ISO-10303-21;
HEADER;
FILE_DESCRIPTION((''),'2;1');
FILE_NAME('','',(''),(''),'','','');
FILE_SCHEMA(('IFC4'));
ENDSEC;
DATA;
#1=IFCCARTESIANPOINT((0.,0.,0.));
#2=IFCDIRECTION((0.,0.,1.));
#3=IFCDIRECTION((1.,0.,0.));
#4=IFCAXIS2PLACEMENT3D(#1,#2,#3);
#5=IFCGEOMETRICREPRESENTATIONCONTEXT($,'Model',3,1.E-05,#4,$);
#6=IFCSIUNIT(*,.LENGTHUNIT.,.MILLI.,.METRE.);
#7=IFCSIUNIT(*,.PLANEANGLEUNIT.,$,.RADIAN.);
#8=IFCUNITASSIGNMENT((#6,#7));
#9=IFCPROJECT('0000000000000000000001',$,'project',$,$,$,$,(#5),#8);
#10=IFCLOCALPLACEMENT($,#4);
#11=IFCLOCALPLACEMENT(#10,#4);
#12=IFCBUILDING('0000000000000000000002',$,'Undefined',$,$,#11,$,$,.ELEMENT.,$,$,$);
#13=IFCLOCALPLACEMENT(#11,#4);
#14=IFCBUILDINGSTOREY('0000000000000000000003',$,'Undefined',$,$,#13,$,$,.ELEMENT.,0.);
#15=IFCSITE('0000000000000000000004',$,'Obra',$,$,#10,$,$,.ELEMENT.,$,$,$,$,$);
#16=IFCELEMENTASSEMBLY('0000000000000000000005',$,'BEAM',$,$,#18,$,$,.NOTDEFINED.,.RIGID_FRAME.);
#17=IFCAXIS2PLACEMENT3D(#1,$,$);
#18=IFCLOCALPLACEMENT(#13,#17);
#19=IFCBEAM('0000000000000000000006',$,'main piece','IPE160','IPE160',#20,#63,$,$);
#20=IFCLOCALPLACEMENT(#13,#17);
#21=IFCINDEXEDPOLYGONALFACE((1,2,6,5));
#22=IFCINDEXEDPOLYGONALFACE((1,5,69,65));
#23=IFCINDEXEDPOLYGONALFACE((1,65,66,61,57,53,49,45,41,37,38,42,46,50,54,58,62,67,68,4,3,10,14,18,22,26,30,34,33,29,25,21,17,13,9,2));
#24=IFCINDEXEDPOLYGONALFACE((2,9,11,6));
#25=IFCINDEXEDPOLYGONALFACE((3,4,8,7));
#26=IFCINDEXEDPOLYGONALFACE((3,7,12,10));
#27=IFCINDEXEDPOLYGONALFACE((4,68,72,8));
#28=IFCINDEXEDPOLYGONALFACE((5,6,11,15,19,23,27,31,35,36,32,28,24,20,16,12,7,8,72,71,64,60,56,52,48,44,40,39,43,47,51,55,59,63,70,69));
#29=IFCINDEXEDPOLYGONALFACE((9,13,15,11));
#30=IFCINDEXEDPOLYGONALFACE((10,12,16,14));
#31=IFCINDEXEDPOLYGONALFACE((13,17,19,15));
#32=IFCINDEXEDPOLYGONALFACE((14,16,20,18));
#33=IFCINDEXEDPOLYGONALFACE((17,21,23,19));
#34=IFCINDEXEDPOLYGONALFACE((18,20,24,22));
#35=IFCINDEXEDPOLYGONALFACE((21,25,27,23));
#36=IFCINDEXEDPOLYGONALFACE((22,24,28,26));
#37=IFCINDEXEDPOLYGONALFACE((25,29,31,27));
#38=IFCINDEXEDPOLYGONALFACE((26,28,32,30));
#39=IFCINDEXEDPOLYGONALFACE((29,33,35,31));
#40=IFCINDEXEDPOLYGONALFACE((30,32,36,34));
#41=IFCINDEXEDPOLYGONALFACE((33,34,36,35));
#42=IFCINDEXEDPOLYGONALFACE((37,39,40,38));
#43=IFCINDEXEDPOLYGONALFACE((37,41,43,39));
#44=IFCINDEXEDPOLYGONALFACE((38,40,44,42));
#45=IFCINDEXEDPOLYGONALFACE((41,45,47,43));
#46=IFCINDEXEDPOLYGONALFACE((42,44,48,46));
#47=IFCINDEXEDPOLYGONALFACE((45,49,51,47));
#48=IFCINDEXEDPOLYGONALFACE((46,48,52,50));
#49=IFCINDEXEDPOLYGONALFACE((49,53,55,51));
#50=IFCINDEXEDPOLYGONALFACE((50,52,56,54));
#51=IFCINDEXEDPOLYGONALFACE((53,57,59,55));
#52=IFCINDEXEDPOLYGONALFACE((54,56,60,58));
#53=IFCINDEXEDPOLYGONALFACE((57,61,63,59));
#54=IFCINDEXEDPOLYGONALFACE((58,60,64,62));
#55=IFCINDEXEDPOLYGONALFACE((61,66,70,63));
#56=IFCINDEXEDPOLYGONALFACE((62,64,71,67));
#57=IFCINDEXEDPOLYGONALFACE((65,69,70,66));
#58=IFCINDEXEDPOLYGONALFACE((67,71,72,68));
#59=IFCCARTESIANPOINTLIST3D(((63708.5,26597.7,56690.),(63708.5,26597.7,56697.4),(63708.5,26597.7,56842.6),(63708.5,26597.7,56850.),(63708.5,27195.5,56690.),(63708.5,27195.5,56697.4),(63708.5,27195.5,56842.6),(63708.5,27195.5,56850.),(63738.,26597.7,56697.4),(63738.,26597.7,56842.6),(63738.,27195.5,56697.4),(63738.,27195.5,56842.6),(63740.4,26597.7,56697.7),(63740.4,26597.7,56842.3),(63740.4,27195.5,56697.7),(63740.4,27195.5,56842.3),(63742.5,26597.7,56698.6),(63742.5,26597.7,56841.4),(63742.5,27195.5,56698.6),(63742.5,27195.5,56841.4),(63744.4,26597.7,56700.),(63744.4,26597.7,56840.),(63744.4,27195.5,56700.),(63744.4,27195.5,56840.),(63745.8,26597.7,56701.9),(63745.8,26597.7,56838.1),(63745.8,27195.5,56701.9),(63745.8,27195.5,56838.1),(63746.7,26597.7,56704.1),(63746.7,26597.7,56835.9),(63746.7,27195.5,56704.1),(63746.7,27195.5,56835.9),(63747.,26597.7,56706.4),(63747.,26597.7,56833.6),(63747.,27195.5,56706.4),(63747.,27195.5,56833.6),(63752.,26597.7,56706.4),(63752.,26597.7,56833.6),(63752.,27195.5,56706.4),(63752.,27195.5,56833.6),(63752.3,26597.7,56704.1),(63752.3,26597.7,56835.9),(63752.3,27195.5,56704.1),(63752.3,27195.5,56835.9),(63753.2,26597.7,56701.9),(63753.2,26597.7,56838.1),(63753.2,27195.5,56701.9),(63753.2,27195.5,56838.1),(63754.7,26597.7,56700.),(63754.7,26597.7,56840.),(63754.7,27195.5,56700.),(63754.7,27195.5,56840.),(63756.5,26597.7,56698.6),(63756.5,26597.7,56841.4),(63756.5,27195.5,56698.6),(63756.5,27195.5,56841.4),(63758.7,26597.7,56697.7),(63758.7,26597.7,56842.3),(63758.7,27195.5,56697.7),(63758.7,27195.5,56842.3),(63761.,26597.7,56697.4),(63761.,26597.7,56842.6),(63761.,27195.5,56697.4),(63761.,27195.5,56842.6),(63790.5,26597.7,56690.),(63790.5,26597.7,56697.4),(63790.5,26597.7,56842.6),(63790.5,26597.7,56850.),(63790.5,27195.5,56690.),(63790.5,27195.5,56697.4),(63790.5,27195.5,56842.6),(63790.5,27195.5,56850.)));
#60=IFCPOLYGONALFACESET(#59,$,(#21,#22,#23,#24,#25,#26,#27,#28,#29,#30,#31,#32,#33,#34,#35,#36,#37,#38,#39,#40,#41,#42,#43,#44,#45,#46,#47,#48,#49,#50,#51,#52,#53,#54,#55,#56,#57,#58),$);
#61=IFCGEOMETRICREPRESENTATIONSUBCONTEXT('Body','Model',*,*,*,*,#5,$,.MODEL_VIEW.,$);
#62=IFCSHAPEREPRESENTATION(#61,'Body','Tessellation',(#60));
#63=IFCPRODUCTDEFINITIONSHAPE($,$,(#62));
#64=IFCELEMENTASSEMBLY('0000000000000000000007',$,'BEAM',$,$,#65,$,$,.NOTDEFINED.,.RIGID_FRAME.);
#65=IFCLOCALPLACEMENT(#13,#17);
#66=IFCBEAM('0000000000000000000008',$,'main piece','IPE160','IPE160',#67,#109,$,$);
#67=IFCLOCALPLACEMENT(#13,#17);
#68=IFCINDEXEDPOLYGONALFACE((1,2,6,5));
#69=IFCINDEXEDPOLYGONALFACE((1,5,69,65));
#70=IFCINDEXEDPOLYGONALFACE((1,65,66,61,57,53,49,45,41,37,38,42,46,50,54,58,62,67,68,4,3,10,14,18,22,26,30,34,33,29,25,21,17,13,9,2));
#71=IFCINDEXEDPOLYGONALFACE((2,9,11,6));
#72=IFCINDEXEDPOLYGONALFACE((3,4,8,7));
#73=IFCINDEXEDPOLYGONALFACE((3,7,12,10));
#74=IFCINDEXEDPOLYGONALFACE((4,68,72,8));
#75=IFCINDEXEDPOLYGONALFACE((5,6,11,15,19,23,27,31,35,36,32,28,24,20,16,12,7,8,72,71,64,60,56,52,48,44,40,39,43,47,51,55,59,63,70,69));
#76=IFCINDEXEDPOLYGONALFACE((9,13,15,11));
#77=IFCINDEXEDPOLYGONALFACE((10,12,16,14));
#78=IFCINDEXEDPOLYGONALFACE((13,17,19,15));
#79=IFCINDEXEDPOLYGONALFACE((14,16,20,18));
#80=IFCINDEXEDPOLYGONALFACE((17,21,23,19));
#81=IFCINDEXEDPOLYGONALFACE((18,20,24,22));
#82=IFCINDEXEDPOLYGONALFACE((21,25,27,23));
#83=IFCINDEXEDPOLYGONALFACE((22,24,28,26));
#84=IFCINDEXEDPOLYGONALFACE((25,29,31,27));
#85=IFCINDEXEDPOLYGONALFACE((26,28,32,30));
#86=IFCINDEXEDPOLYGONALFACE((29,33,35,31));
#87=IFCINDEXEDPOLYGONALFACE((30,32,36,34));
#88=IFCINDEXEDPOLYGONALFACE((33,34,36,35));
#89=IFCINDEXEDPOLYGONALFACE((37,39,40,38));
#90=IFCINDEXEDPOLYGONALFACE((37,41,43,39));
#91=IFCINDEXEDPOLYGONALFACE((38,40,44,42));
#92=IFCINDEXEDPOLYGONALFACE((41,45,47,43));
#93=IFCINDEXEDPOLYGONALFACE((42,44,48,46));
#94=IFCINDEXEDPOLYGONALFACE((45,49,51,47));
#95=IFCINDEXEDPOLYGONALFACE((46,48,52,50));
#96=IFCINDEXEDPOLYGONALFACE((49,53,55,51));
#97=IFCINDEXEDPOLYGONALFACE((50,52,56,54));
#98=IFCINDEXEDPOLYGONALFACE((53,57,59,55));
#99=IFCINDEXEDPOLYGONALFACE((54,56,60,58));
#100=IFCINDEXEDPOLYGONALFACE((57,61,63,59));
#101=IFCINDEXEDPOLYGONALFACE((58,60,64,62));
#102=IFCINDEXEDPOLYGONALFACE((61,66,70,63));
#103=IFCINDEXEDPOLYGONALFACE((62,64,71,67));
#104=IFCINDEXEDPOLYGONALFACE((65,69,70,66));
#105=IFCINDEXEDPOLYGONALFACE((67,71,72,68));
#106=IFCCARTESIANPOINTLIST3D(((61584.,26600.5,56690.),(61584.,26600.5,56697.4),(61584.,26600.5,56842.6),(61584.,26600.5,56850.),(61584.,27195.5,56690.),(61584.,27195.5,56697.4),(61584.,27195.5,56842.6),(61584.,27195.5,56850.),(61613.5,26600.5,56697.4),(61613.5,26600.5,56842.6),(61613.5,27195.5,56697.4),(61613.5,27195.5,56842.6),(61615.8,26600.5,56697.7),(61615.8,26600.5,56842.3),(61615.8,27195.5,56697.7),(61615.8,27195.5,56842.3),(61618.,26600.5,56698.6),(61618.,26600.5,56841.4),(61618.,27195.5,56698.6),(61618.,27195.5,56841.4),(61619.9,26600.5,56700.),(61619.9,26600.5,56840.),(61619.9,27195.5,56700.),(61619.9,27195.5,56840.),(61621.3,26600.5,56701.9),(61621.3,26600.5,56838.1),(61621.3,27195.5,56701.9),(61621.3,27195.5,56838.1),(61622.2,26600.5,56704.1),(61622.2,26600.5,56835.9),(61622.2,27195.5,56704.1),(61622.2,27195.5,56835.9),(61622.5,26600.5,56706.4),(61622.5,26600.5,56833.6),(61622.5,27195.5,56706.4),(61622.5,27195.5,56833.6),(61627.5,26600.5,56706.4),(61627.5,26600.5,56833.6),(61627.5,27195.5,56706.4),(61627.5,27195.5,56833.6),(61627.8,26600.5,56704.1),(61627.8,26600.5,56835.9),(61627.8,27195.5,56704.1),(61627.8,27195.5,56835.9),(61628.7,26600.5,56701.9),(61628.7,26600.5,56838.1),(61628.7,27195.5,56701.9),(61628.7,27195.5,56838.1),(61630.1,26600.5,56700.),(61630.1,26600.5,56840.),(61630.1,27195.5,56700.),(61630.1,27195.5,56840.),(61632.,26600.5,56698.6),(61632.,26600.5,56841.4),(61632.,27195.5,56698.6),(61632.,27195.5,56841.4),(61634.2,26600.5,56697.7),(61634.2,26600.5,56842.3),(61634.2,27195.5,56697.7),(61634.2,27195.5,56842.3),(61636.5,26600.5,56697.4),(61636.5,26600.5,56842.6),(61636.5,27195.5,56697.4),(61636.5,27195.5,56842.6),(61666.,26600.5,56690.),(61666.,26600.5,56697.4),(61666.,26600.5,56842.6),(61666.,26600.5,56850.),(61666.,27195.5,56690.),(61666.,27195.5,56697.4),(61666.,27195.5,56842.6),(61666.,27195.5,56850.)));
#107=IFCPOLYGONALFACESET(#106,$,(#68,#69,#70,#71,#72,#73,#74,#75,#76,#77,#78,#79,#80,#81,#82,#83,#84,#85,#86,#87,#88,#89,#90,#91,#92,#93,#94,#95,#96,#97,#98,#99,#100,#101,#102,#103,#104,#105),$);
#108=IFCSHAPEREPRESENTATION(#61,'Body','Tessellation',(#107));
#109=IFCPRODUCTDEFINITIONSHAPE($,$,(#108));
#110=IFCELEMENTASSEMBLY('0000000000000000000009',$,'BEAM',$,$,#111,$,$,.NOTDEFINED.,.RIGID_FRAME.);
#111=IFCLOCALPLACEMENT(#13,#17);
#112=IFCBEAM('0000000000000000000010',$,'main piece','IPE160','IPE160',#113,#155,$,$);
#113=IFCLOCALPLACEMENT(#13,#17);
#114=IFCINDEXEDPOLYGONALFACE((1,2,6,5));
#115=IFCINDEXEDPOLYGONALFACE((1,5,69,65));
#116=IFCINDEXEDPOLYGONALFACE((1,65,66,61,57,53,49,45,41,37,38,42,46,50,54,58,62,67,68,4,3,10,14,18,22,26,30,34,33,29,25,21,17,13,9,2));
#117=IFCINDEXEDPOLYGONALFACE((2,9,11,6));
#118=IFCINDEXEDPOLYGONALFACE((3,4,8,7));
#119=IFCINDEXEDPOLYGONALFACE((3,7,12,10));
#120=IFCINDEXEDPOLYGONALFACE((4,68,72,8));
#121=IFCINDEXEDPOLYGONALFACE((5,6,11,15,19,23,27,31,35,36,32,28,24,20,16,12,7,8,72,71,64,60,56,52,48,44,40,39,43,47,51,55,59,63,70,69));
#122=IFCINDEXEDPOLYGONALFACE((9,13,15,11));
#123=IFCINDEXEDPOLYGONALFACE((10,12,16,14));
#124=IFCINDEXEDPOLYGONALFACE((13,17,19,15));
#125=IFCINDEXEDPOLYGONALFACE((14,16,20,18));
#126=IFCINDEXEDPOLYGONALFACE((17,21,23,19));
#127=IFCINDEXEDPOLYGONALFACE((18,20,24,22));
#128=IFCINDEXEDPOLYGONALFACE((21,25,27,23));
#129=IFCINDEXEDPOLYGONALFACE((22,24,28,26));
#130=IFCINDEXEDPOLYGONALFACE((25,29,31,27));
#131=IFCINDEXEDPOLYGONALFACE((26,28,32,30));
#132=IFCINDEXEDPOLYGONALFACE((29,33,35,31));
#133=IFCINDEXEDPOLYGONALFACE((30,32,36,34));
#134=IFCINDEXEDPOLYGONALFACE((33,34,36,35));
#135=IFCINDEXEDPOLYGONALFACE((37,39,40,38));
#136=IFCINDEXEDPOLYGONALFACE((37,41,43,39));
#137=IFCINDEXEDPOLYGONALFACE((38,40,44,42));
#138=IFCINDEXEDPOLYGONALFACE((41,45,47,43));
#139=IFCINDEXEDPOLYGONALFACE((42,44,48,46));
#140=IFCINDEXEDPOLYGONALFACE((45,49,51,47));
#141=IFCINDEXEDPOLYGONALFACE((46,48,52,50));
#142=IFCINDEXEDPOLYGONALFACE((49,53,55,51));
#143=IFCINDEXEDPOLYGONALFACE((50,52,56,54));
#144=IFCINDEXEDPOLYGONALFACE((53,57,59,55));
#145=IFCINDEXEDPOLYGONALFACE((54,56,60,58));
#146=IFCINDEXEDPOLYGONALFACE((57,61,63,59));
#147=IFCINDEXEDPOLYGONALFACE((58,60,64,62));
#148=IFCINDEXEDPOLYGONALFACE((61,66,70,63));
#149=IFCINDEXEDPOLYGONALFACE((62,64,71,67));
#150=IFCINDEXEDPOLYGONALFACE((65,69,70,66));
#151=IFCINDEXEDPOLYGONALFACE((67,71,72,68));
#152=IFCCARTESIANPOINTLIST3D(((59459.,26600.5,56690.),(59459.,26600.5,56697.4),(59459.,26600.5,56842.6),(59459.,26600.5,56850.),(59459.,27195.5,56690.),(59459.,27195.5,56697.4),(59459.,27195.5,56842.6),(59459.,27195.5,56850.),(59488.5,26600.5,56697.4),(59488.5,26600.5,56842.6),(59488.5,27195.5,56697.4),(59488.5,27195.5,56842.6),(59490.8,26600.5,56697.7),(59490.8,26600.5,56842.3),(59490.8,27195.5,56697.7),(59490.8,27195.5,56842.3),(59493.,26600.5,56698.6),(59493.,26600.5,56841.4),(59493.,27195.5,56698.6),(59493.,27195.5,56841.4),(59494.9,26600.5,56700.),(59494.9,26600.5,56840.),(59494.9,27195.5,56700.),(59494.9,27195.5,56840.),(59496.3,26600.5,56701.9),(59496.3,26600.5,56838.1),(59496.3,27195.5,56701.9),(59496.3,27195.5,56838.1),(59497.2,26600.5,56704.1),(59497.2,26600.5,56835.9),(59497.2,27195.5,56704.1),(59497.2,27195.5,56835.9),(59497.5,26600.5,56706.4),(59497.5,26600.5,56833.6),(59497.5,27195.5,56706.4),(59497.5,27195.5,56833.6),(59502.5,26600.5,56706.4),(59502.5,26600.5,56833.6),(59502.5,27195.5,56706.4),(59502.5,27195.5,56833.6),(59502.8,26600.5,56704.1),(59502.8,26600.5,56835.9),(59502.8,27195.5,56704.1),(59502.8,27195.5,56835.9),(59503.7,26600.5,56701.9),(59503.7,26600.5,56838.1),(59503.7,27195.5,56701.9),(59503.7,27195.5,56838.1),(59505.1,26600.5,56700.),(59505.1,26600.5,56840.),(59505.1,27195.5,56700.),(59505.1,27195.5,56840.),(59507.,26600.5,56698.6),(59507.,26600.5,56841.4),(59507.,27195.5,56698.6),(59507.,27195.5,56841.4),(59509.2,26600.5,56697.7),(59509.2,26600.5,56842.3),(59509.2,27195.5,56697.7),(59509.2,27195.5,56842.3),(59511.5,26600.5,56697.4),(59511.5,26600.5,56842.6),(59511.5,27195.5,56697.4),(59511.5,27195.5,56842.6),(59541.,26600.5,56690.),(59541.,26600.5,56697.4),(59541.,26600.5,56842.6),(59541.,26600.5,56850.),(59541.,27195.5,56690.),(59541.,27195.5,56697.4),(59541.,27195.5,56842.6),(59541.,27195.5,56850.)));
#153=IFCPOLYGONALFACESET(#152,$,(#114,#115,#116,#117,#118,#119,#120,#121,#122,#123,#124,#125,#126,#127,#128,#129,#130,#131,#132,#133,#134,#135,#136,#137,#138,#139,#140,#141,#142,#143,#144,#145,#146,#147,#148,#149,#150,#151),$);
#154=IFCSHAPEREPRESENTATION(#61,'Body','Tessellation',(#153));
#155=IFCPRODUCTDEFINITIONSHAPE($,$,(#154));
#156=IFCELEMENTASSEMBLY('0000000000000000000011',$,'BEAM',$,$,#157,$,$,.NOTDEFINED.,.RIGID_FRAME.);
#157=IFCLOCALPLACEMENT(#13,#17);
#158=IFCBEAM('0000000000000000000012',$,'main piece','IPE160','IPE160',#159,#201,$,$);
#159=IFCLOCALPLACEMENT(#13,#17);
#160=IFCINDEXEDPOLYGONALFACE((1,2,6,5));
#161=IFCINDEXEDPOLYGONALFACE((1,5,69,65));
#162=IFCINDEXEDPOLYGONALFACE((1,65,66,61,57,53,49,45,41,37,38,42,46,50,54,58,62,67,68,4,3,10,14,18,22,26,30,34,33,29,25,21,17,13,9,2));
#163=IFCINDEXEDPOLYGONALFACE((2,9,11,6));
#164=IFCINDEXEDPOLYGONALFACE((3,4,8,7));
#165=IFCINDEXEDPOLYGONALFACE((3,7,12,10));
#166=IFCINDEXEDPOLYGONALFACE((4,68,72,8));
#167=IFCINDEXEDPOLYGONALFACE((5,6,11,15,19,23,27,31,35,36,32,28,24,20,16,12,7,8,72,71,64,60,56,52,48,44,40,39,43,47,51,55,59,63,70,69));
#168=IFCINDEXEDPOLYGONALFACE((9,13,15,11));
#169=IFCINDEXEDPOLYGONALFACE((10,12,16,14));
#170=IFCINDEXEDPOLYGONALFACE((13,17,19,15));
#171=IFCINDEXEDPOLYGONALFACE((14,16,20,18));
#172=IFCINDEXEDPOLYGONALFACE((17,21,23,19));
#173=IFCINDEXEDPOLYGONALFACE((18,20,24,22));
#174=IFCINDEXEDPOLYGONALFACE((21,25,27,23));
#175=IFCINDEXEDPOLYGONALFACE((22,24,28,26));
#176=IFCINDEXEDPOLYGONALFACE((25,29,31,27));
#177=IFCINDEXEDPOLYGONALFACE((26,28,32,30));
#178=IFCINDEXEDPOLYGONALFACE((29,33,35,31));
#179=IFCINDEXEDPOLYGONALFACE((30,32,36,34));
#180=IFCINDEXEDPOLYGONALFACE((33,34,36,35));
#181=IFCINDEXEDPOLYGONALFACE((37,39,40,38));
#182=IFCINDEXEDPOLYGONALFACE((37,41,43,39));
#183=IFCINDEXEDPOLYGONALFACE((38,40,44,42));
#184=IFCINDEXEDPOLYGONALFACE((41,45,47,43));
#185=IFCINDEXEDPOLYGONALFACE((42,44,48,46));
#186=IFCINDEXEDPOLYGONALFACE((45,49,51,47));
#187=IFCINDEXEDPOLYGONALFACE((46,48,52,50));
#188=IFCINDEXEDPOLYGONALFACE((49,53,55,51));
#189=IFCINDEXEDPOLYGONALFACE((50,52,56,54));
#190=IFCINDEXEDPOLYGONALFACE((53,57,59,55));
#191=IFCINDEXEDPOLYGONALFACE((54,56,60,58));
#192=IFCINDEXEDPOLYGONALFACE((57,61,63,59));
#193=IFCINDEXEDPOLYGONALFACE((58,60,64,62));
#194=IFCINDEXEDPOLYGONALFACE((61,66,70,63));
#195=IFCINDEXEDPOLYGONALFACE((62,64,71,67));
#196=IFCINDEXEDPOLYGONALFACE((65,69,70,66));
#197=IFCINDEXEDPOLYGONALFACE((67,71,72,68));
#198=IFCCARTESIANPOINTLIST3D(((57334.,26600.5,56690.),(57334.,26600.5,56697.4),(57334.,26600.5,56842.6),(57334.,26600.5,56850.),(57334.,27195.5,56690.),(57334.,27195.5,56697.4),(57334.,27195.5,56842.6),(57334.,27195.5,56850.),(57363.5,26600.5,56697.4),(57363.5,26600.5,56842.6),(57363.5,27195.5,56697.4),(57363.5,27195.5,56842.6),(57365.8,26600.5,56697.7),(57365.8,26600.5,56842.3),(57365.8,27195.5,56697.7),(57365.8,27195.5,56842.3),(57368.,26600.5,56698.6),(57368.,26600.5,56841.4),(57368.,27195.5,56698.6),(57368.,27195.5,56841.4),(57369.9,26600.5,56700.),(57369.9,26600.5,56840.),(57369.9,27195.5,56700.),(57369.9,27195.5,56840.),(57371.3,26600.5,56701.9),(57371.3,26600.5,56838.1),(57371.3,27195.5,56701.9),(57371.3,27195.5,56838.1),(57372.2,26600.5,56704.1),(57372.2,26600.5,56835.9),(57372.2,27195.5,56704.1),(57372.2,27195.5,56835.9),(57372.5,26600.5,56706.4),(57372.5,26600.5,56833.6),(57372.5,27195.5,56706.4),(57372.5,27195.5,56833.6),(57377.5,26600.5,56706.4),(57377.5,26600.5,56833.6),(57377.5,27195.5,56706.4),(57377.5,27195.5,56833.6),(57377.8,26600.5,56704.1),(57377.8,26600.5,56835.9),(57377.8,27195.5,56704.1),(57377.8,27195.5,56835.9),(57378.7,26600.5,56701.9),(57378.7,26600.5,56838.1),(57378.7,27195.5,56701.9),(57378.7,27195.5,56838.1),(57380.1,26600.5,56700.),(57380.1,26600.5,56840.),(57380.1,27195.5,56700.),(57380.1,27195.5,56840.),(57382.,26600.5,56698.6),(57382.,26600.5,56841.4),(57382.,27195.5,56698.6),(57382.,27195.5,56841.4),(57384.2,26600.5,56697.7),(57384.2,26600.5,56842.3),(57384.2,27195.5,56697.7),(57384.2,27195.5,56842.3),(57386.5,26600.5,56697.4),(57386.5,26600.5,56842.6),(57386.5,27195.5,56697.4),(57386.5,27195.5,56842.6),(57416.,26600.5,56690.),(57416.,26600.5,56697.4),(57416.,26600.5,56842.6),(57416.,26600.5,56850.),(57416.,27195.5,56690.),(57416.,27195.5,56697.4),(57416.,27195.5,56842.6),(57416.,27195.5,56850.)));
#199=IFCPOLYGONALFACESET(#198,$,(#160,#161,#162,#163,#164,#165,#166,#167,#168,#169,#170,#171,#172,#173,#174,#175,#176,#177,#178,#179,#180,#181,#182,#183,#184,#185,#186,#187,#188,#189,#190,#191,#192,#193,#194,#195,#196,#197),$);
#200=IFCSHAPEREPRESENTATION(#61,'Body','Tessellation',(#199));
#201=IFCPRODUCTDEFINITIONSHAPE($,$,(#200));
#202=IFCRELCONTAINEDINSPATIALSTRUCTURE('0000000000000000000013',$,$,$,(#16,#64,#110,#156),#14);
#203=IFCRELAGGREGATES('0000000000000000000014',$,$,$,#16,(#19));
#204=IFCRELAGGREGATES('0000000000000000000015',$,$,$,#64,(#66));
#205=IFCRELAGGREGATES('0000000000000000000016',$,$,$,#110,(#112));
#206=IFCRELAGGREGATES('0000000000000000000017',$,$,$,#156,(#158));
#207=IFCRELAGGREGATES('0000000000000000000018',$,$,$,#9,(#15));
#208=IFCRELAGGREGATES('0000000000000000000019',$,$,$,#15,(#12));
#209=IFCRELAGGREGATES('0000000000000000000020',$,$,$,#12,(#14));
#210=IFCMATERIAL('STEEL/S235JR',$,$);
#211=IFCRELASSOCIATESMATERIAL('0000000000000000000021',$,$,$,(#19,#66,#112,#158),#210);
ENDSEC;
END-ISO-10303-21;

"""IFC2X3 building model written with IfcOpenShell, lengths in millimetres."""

from ifc_helpers import new_model, si_unit, frame, origin_with_axes, origin_2d_with_axis, place, context, subcontext, project, spatial, i_section, extrude, material, element, aggregate, save


model = new_model("IFC2X3")

# Units and contexts
model_context = context("Model", 3, precision=1e-05, world=origin_with_axes())
body_context = subcontext(model_context, "Body", "Model", "MODEL_VIEW")
ifc_project = project(units=[si_unit("LENGTHUNIT", "METRE", prefix="MILLI"), si_unit("PLANEANGLEUNIT", "RADIAN")], contexts=[model_context])

# Site, building, storey
site_placement = place(None, origin_with_axes())
site = spatial("IfcSite", under=ifc_project, at=site_placement, Name="Obra", CompositionType="ELEMENT")
building_placement = place(site_placement, origin_with_axes())
building = spatial("IfcBuilding", under=site, at=building_placement, Name="Undefined", CompositionType="ELEMENT")
storey_placement = place(building_placement, origin_with_axes())
storey = spatial("IfcBuildingStorey", under=building, at=storey_placement, Name="Undefined", CompositionType="ELEMENT", Elevation=0.0)

# Element assemblies, beams
ifc_material_1 = material(Name="STEEL/S235JR")
assembly_1_placement = place(storey_placement, origin_with_axes())
assembly_1 = element("IfcElementAssembly", 1, at=assembly_1_placement, inside=storey, Name="BEAM", AssemblyPlace="NOTDEFINED", PredefinedType="RIGID_FRAME")
beam_1_placement = place(assembly_1_placement, frame((63749.5, 26597.7, 56770.0), z_axis=(0.0, 0.0, 1.0), x_axis=(0.0, 1.0, 0.0)))
beam_1 = element("IfcBeam", 2, at=beam_1_placement, material=ifc_material_1, Name="main piece", Description="IPE160", ObjectType="IPE160", context=body_context, shape_type="SweptSolid", body=[
    extrude(i_section(OverallWidth=82.0, OverallDepth=160.0, WebThickness=5.0, FlangeThickness=7.4, FilletRadius=9.0, at=origin_2d_with_axis()), frame((597.8, 0.0, 0.0), z_axis=(-1.0, 0.0, 0.0), x_axis=(0.0, -1.0, 0.0)), (0.0, 0.0, 1.0), 597.8),
])
aggregate(assembly_1, [beam_1])
assembly_2_placement = place(storey_placement, origin_with_axes())
assembly_2 = element("IfcElementAssembly", 3, at=assembly_2_placement, inside=storey, Name="BEAM", AssemblyPlace="NOTDEFINED", PredefinedType="RIGID_FRAME")
beam_2_placement = place(assembly_2_placement, frame((61625.0, 27195.5, 56770.0), z_axis=(0.0, 0.0, 1.0), x_axis=(0.0, -1.0, 0.0)))
beam_2 = element("IfcBeam", 4, at=beam_2_placement, material=ifc_material_1, Name="main piece", Description="IPE160", ObjectType="IPE160", context=body_context, shape_type="SweptSolid", body=[
    extrude(i_section(OverallWidth=82.0, OverallDepth=160.0, WebThickness=5.0, FlangeThickness=7.4, FilletRadius=9.0, at=origin_2d_with_axis()), frame((595.0, 0.0, 0.0), z_axis=(-1.0, 0.0, 0.0), x_axis=(0.0, -1.0, 0.0)), (0.0, 0.0, 1.0), 595.0),
])
aggregate(assembly_2, [beam_2])
assembly_3_placement = place(storey_placement, origin_with_axes())
assembly_3 = element("IfcElementAssembly", 5, at=assembly_3_placement, inside=storey, Name="BEAM", AssemblyPlace="NOTDEFINED", PredefinedType="RIGID_FRAME")
beam_3_placement = place(assembly_3_placement, frame((59500.0, 26600.5, 56770.0), z_axis=(0.0, 0.0, 1.0), x_axis=(0.0, 1.0, 0.0)))
beam_3 = element("IfcBeam", 6, at=beam_3_placement, material=ifc_material_1, Name="main piece", Description="IPE160", ObjectType="IPE160", context=body_context, shape_type="SweptSolid", body=[
    extrude(i_section(OverallWidth=82.0, OverallDepth=160.0, WebThickness=5.0, FlangeThickness=7.4, FilletRadius=9.0, at=origin_2d_with_axis()), frame((595.0, 0.0, 0.0), z_axis=(-1.0, 0.0, 0.0), x_axis=(0.0, -1.0, 0.0)), (0.0, 0.0, 1.0), 595.0),
])
aggregate(assembly_3, [beam_3])
assembly_4_placement = place(storey_placement, origin_with_axes())
assembly_4 = element("IfcElementAssembly", 7, at=assembly_4_placement, inside=storey, Name="BEAM", AssemblyPlace="NOTDEFINED", PredefinedType="RIGID_FRAME")
beam_4_placement = place(assembly_4_placement, frame((57375.0, 27195.5, 56770.0), z_axis=(0.0, 0.0, 1.0), x_axis=(0.0, -1.0, 0.0)))
beam_4 = element("IfcBeam", 8, at=beam_4_placement, material=ifc_material_1, Name="main piece", Description="IPE160", ObjectType="IPE160", context=body_context, shape_type="SweptSolid", body=[
    extrude(i_section(OverallWidth=82.0, OverallDepth=160.0, WebThickness=5.0, FlangeThickness=7.4, FilletRadius=9.0, at=origin_2d_with_axis()), frame((595.0, 0.0, 0.0), z_axis=(-1.0, 0.0, 0.0), x_axis=(0.0, -1.0, 0.0)), (0.0, 0.0, 1.0), 595.0),
])
aggregate(assembly_4, [beam_4])

save(model, "model.ifc")
